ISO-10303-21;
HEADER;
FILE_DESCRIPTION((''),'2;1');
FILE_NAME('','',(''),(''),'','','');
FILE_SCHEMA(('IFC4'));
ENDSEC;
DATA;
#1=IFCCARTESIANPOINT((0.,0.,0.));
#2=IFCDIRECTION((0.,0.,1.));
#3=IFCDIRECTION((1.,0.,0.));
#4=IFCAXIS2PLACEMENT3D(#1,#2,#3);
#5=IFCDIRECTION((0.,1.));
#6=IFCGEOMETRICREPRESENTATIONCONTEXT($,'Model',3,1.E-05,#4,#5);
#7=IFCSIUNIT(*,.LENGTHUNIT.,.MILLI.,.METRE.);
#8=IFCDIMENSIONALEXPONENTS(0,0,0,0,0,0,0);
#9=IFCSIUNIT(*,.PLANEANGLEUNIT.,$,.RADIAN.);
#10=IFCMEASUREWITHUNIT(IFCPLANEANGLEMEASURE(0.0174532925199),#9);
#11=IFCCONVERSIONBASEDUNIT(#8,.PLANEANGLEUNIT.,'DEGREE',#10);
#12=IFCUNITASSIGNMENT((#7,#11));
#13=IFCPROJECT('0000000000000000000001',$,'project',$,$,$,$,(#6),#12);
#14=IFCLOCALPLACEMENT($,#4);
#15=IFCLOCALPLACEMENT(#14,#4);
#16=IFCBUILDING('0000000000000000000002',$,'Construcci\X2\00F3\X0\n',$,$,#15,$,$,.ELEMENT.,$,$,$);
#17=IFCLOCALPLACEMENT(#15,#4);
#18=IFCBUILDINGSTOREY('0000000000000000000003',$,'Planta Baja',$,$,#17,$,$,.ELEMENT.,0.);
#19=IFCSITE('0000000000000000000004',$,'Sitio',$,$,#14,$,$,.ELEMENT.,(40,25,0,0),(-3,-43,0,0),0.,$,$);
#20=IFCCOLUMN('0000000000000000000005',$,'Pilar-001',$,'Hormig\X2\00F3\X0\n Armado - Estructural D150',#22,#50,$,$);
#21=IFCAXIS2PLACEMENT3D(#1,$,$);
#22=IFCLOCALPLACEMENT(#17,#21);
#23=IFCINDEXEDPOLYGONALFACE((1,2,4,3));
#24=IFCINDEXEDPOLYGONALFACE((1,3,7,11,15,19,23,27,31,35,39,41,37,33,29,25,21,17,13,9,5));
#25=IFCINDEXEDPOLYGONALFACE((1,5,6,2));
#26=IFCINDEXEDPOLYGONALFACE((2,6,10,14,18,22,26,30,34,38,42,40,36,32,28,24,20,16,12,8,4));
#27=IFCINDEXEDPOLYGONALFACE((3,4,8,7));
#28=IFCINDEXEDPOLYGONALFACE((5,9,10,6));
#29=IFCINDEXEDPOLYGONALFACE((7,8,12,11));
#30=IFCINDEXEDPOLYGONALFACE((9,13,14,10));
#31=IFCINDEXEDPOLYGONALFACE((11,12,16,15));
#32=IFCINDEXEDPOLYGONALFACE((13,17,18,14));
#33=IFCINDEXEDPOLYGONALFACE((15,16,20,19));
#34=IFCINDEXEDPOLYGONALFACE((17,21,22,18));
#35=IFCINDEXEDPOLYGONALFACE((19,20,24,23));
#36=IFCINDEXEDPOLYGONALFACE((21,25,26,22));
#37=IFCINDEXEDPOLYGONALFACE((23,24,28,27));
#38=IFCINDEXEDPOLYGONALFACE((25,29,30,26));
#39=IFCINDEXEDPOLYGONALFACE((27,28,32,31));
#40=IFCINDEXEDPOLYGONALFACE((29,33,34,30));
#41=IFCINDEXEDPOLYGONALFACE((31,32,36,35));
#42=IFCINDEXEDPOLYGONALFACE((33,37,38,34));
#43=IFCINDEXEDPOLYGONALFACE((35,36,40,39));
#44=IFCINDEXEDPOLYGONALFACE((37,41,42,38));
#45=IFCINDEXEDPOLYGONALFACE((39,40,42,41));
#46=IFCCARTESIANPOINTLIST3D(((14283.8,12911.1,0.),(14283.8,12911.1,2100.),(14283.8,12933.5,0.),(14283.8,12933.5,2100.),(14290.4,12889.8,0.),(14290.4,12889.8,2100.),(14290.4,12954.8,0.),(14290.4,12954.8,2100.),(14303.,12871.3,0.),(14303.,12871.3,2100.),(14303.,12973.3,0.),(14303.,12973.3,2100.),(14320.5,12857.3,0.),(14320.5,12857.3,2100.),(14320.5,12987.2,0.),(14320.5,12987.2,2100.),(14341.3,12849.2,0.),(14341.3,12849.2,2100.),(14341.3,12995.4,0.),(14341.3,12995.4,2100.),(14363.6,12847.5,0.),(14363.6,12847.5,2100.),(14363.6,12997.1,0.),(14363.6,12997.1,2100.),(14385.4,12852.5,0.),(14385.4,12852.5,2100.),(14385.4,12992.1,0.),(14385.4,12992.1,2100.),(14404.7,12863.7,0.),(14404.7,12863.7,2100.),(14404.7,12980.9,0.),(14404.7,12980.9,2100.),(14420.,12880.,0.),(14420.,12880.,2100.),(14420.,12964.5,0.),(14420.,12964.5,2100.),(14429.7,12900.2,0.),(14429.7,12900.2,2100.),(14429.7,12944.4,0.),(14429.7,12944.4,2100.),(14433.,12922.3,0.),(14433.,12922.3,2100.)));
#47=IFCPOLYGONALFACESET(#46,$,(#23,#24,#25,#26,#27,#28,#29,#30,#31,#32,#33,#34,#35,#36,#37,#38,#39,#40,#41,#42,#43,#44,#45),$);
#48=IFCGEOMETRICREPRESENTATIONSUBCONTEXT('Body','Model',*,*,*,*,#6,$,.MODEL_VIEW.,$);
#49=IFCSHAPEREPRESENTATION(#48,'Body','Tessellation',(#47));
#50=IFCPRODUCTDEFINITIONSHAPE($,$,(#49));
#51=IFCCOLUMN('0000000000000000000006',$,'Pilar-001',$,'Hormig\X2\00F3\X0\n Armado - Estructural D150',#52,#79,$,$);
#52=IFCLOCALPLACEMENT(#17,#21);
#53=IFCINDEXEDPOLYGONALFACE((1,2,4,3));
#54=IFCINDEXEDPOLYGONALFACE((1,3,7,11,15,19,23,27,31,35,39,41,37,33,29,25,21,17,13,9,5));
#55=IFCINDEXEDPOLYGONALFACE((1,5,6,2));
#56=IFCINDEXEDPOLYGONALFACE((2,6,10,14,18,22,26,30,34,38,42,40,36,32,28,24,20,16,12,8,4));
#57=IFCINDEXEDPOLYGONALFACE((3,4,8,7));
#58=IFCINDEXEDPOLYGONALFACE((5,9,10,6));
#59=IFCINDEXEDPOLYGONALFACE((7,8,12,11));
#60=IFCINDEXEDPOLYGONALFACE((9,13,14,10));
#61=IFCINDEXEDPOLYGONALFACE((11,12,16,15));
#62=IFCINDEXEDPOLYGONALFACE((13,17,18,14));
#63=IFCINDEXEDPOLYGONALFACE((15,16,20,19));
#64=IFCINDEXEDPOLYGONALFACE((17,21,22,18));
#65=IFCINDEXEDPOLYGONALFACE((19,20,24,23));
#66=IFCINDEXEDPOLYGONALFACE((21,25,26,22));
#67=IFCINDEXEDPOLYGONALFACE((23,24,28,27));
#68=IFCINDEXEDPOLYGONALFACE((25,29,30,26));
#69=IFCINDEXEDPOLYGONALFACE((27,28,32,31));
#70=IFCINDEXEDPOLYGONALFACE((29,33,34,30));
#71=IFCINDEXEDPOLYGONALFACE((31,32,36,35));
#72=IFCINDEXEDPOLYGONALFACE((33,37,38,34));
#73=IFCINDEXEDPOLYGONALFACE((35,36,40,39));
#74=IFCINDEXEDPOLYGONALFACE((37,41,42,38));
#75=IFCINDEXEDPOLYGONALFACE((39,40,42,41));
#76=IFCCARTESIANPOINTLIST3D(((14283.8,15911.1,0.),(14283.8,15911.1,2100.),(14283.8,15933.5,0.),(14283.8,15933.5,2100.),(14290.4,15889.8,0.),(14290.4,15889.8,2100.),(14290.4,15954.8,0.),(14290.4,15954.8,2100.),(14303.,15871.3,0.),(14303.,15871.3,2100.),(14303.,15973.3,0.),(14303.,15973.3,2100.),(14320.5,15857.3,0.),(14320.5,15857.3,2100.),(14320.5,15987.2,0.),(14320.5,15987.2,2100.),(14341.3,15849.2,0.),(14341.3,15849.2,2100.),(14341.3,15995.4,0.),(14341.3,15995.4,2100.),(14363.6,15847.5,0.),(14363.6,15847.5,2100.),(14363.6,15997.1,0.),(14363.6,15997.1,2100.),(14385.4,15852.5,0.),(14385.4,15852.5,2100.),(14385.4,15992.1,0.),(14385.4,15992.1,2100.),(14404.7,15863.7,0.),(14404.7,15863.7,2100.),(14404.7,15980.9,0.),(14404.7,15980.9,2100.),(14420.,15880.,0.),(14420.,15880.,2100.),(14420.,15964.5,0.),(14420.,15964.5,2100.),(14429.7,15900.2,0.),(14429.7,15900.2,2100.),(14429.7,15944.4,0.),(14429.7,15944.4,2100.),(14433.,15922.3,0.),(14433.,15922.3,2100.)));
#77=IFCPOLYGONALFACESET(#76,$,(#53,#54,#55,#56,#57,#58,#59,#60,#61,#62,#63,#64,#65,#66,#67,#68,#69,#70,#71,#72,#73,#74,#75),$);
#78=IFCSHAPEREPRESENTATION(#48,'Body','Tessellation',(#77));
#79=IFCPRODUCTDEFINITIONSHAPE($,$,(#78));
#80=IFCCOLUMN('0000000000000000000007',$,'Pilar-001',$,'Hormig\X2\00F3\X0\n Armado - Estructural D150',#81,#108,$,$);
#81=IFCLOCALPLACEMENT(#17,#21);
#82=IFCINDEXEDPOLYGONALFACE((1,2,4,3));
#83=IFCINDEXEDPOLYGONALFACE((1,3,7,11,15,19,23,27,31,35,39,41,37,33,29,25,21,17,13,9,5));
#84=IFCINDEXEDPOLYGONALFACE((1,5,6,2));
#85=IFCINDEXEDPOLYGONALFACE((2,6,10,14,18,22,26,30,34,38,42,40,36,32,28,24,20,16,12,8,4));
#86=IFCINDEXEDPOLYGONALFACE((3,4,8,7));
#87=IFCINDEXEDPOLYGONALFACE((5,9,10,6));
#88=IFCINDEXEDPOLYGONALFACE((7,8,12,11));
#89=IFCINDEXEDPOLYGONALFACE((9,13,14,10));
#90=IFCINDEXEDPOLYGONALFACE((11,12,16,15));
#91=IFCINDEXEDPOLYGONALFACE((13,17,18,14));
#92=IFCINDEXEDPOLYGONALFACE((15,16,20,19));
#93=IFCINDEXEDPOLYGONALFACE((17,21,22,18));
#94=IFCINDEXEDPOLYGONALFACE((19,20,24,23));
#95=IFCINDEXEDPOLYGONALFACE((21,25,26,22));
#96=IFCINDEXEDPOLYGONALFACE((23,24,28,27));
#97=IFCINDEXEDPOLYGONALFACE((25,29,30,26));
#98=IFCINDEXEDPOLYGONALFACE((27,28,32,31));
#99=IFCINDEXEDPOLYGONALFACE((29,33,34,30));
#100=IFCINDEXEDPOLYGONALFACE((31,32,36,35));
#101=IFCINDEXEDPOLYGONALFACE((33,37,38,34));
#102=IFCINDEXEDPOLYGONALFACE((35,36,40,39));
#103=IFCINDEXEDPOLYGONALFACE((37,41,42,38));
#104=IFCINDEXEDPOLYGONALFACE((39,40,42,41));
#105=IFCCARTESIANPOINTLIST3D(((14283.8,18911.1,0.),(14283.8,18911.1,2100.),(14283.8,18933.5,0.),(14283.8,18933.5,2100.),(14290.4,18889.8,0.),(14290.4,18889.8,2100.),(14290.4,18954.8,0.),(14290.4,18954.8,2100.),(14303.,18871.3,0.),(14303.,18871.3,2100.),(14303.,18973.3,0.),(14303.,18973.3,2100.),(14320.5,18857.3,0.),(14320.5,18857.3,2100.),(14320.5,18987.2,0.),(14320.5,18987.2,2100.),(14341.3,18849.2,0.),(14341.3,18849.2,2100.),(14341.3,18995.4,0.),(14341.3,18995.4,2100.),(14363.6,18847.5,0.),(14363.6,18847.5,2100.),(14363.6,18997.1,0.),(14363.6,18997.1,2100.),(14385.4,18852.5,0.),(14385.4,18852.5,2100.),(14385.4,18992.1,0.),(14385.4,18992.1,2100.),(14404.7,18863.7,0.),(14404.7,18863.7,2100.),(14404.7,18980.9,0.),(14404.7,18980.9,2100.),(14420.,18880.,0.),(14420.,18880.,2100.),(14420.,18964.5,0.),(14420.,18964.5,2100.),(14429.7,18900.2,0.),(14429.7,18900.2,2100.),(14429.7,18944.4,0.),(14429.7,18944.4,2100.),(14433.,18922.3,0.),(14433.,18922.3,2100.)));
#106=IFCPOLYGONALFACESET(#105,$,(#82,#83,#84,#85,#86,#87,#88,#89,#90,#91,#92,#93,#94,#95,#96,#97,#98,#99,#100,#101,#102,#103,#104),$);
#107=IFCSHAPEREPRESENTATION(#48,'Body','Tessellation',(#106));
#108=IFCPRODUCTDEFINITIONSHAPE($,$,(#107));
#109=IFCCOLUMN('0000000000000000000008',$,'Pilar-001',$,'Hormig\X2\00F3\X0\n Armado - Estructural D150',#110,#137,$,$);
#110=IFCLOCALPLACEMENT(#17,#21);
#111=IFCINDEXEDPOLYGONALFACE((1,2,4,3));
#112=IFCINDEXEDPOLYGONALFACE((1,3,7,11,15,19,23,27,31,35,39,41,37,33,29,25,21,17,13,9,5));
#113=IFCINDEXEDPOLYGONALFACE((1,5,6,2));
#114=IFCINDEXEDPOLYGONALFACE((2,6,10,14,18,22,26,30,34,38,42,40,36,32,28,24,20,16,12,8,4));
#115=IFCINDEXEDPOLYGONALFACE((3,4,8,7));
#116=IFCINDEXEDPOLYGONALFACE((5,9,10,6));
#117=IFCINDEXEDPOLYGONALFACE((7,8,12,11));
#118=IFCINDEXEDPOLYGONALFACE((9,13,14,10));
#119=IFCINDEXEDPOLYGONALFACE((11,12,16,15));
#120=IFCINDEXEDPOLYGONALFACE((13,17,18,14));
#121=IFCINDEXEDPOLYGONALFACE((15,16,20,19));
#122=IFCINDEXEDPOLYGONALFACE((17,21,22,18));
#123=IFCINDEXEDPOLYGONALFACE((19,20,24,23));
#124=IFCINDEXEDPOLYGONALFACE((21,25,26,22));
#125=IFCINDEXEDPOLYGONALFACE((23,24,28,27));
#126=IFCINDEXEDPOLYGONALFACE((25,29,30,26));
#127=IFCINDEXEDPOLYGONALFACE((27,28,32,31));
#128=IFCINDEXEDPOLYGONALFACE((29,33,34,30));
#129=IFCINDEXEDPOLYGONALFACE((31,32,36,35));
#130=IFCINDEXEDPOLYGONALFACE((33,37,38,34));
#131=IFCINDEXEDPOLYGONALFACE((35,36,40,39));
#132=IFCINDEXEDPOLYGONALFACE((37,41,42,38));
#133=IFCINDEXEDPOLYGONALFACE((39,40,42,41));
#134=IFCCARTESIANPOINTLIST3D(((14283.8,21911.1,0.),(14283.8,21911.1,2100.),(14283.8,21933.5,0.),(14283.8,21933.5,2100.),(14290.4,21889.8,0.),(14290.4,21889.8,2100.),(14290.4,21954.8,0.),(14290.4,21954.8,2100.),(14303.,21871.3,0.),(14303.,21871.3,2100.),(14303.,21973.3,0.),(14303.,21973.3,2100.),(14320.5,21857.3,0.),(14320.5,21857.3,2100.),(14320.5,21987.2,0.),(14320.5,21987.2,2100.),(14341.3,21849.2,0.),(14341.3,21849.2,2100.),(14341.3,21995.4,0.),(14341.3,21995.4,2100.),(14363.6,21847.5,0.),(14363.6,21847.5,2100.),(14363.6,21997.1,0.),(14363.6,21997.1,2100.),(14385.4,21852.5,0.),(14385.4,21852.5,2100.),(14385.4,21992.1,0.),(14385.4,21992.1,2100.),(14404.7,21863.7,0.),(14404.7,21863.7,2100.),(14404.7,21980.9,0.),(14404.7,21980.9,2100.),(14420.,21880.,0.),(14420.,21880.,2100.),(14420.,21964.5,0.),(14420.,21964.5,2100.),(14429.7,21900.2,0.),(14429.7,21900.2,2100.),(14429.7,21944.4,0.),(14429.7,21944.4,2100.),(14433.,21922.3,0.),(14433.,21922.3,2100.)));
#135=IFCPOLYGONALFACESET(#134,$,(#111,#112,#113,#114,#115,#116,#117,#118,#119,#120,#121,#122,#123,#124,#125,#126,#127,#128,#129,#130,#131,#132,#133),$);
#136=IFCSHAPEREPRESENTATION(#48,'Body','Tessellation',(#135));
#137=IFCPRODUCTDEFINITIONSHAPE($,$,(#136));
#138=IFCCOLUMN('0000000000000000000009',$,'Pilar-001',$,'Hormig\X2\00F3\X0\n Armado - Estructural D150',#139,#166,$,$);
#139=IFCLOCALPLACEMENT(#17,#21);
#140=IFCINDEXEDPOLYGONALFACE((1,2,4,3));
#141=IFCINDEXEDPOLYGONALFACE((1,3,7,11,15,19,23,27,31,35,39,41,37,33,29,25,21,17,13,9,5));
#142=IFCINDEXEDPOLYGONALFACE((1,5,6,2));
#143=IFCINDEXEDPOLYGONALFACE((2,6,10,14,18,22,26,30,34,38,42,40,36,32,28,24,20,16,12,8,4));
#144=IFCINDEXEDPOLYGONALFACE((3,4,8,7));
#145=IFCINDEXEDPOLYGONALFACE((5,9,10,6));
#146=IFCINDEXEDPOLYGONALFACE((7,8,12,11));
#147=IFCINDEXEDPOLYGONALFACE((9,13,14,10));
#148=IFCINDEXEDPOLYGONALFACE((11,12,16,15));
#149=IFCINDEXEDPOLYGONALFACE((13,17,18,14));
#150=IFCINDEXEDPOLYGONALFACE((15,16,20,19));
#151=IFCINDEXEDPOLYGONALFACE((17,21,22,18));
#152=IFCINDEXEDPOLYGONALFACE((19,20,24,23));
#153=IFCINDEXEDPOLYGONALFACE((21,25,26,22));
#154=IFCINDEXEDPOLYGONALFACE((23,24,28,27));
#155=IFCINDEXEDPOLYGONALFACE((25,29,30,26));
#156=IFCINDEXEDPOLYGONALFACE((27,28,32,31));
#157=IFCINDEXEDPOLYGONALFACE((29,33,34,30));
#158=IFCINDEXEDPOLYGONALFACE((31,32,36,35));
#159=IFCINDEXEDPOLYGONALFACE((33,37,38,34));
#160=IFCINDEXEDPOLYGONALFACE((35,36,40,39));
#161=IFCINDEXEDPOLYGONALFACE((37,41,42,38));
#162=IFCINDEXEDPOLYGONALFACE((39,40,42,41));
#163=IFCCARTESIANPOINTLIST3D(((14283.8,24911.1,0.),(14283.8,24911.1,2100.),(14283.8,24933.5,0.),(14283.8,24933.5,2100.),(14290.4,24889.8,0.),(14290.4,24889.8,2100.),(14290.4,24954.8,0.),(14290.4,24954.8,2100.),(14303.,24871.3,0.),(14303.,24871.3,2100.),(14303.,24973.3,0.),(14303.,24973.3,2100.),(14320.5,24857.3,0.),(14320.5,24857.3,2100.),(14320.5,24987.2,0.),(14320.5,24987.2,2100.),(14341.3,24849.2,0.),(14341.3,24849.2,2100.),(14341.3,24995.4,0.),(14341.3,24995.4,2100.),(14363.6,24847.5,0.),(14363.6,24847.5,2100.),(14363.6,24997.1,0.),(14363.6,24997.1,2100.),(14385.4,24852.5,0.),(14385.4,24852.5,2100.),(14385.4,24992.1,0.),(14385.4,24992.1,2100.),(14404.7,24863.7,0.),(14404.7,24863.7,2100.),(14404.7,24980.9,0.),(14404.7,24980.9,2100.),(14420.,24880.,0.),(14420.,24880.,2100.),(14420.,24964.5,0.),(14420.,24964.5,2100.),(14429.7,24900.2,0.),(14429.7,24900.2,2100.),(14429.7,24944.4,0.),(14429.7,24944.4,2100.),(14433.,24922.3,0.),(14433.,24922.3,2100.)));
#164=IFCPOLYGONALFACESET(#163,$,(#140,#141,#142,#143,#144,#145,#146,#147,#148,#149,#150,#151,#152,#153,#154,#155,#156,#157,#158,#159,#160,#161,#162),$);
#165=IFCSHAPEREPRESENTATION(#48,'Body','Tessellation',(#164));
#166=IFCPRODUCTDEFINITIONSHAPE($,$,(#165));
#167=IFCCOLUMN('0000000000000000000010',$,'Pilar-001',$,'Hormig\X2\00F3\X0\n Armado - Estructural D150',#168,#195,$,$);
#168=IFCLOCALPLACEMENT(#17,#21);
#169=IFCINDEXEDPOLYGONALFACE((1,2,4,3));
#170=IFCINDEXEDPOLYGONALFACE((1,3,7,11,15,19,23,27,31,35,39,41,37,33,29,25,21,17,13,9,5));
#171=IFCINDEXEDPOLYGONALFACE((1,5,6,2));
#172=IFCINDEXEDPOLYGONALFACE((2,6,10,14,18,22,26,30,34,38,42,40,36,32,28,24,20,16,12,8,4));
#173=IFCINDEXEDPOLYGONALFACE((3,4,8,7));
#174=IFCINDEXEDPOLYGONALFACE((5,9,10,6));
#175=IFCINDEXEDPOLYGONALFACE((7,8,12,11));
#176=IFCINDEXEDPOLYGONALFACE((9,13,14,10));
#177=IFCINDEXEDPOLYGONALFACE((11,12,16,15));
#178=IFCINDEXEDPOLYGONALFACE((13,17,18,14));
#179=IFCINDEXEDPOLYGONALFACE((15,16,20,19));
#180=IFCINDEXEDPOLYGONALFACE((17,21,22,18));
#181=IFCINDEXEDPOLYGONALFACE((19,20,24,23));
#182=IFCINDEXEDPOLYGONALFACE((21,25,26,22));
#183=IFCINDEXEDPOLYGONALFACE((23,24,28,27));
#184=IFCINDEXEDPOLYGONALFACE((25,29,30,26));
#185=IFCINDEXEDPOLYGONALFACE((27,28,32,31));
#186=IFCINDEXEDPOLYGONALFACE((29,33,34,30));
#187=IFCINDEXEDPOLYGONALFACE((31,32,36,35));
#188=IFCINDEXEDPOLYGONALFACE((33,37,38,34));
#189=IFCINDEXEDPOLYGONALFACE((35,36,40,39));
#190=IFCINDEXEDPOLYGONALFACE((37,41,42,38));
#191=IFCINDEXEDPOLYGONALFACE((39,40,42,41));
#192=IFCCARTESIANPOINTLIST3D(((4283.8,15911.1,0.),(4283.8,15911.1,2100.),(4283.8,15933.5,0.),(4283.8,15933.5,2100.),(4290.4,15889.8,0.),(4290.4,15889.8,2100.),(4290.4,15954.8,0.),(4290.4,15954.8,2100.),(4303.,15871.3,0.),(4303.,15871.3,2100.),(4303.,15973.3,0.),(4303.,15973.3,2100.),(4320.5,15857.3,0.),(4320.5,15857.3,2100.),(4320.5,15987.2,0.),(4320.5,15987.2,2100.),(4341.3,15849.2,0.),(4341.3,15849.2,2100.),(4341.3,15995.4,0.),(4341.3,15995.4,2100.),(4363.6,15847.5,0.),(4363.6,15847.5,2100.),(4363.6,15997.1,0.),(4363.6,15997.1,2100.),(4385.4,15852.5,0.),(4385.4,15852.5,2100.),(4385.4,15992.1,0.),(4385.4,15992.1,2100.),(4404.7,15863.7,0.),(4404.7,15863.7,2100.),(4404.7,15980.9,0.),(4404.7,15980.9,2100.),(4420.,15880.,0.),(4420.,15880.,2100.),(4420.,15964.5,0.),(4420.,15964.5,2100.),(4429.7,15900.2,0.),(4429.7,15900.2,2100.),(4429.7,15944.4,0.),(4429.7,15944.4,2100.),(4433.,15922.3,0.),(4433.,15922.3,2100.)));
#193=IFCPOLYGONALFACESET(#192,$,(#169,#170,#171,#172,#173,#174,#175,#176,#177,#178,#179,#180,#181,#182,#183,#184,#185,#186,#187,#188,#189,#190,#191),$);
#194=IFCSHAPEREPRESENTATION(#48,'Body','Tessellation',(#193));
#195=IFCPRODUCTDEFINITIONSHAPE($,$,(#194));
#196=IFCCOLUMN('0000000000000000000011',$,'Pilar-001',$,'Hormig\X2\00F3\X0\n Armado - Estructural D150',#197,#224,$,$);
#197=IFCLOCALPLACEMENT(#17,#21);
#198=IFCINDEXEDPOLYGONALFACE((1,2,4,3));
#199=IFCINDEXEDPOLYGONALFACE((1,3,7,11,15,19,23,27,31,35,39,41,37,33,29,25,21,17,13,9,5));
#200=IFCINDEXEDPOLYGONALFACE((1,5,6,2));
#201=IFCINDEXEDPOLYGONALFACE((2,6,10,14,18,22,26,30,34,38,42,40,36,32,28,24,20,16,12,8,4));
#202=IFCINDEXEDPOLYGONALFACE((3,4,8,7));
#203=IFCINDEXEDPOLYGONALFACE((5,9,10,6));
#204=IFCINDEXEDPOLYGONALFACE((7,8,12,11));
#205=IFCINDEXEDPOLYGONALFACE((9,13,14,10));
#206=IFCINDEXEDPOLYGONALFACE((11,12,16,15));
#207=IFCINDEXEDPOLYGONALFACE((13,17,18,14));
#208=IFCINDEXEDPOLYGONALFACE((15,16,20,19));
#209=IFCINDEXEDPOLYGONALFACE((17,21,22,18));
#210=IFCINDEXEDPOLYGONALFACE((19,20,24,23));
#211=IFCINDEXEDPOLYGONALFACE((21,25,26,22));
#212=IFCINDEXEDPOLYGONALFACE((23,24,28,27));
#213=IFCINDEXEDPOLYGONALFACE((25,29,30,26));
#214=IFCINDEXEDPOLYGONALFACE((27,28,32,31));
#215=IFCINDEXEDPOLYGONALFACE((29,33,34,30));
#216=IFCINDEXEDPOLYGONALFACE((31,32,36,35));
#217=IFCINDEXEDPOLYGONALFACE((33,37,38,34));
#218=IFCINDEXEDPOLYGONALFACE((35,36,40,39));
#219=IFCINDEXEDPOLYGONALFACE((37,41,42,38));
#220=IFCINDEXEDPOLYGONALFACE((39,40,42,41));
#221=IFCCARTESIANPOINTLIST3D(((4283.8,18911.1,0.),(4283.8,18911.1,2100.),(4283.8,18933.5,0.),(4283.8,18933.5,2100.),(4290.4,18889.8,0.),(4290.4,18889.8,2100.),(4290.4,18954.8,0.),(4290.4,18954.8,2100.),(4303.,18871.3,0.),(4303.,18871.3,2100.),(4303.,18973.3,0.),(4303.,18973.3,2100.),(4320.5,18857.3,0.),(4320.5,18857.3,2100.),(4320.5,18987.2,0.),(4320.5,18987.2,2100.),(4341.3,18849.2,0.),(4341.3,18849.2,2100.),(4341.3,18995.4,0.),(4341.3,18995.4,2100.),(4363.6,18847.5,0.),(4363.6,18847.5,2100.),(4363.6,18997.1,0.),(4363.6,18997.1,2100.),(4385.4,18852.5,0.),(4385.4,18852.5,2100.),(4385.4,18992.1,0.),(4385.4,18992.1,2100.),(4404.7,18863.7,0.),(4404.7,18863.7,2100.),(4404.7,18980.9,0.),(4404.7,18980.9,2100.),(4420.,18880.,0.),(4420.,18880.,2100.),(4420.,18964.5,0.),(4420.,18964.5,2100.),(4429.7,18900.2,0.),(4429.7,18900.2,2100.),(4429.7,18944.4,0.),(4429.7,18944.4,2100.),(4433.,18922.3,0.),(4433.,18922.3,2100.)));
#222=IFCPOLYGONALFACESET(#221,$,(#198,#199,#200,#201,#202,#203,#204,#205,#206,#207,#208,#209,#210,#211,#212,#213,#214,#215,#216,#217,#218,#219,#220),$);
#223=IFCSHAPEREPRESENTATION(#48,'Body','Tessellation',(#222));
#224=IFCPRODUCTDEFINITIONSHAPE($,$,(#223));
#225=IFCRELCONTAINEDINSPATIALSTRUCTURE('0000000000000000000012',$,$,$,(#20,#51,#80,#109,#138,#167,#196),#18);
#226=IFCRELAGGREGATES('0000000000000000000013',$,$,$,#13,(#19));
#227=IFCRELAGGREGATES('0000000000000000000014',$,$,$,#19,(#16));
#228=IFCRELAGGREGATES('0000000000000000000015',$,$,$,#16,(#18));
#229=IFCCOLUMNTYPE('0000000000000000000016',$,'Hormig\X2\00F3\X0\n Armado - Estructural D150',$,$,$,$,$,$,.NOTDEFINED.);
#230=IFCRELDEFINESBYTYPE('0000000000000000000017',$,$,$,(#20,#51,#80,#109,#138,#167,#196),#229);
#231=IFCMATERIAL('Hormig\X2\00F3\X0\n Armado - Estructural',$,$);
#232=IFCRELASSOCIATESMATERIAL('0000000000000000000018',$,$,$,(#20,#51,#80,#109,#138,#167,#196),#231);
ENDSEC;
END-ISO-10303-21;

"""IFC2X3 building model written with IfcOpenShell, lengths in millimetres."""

from ifc_helpers import new_model, entity, si_unit, converted_unit, direction, frame, origin_with_axes, origin_2d_with_axis, place, context, subcontext, project, spatial, circle, extrude, material, type_object, element, save


model = new_model("IFC2X3")

# Units and contexts
model_context = context("Model", 3, precision=1e-05, world=origin_with_axes(), true_north=direction((0.0, 1.0)))
body_context = subcontext(model_context, "Body", "Model", "MODEL_VIEW")
ifc_project = project(units=[si_unit("LENGTHUNIT", "METRE", prefix="MILLI"), converted_unit("PLANEANGLEUNIT", "DEGREE", entity("IfcPlaneAngleMeasure", 0.0174532925199), si_unit("PLANEANGLEUNIT", "RADIAN"), dimensions=[0, 0, 0, 0, 0, 0, 0])], contexts=[model_context])

# Site, building, storey
site_placement = place(None, origin_with_axes())
site = spatial("IfcSite", under=ifc_project, at=site_placement, Name="Sitio", CompositionType="ELEMENT", RefLatitude=(40, 25, 0, 0), RefLongitude=(-3, -43, 0, 0), RefElevation=0.0)
building_placement = place(site_placement, origin_with_axes())
building = spatial("IfcBuilding", under=site, at=building_placement, Name="Construcción", CompositionType="ELEMENT")
storey_placement = place(building_placement, origin_with_axes())
storey = spatial("IfcBuildingStorey", under=building, at=storey_placement, Name="Planta Baja", CompositionType="ELEMENT", Elevation=0.0)

# Columns
ifc_material_1 = material(Name="Hormigón Armado - Estructural")
column_type = type_object("IfcColumnType", Name="Hormigón Armado - Estructural D150", PredefinedType="NOTDEFINED")
for number, where, z_axis, x_axis, name in (
    (1, (14358.0, 12922.3, 0.0), (0.0, 0.0, 1.0), (1.0, 0.0, 0.0), "Pilar-001"),
    (2, (14358.0, 15922.3, 0.0), (0.0, 0.0, 1.0), (1.0, 0.0, 0.0), "Pilar-001"),
    (3, (14358.0, 18922.3, 0.0), (0.0, 0.0, 1.0), (1.0, 0.0, 0.0), "Pilar-001"),
    (4, (14358.0, 21922.3, 0.0), (0.0, 0.0, 1.0), (1.0, 0.0, 0.0), "Pilar-001"),
    (5, (14358.0, 24922.3, 0.0), (0.0, 0.0, 1.0), (1.0, 0.0, 0.0), "Pilar-001"),
    (6, (4358.0, 15922.3, 0.0), (0.0, 0.0, 1.0), (1.0, 0.0, 0.0), "Pilar-001"),
    (7, (4358.0, 18922.3, 0.0), (0.0, 0.0, 1.0), (1.0, 0.0, 0.0), "Pilar-001"),
):
    element("IfcColumn", number, at=place(storey_placement, frame(where, z_axis=z_axis, x_axis=x_axis)), inside=storey, type_object=column_type, material=ifc_material_1, Name=name, ObjectType="Hormigón Armado - Estructural D150", context=body_context, shape_type="SweptSolid", body=[
        extrude(circle(Radius=75.0, at=origin_2d_with_axis()), origin_with_axes(), (0.0, 0.0, 1.0), 2100.0),
    ])

save(model, "model.ifc")
